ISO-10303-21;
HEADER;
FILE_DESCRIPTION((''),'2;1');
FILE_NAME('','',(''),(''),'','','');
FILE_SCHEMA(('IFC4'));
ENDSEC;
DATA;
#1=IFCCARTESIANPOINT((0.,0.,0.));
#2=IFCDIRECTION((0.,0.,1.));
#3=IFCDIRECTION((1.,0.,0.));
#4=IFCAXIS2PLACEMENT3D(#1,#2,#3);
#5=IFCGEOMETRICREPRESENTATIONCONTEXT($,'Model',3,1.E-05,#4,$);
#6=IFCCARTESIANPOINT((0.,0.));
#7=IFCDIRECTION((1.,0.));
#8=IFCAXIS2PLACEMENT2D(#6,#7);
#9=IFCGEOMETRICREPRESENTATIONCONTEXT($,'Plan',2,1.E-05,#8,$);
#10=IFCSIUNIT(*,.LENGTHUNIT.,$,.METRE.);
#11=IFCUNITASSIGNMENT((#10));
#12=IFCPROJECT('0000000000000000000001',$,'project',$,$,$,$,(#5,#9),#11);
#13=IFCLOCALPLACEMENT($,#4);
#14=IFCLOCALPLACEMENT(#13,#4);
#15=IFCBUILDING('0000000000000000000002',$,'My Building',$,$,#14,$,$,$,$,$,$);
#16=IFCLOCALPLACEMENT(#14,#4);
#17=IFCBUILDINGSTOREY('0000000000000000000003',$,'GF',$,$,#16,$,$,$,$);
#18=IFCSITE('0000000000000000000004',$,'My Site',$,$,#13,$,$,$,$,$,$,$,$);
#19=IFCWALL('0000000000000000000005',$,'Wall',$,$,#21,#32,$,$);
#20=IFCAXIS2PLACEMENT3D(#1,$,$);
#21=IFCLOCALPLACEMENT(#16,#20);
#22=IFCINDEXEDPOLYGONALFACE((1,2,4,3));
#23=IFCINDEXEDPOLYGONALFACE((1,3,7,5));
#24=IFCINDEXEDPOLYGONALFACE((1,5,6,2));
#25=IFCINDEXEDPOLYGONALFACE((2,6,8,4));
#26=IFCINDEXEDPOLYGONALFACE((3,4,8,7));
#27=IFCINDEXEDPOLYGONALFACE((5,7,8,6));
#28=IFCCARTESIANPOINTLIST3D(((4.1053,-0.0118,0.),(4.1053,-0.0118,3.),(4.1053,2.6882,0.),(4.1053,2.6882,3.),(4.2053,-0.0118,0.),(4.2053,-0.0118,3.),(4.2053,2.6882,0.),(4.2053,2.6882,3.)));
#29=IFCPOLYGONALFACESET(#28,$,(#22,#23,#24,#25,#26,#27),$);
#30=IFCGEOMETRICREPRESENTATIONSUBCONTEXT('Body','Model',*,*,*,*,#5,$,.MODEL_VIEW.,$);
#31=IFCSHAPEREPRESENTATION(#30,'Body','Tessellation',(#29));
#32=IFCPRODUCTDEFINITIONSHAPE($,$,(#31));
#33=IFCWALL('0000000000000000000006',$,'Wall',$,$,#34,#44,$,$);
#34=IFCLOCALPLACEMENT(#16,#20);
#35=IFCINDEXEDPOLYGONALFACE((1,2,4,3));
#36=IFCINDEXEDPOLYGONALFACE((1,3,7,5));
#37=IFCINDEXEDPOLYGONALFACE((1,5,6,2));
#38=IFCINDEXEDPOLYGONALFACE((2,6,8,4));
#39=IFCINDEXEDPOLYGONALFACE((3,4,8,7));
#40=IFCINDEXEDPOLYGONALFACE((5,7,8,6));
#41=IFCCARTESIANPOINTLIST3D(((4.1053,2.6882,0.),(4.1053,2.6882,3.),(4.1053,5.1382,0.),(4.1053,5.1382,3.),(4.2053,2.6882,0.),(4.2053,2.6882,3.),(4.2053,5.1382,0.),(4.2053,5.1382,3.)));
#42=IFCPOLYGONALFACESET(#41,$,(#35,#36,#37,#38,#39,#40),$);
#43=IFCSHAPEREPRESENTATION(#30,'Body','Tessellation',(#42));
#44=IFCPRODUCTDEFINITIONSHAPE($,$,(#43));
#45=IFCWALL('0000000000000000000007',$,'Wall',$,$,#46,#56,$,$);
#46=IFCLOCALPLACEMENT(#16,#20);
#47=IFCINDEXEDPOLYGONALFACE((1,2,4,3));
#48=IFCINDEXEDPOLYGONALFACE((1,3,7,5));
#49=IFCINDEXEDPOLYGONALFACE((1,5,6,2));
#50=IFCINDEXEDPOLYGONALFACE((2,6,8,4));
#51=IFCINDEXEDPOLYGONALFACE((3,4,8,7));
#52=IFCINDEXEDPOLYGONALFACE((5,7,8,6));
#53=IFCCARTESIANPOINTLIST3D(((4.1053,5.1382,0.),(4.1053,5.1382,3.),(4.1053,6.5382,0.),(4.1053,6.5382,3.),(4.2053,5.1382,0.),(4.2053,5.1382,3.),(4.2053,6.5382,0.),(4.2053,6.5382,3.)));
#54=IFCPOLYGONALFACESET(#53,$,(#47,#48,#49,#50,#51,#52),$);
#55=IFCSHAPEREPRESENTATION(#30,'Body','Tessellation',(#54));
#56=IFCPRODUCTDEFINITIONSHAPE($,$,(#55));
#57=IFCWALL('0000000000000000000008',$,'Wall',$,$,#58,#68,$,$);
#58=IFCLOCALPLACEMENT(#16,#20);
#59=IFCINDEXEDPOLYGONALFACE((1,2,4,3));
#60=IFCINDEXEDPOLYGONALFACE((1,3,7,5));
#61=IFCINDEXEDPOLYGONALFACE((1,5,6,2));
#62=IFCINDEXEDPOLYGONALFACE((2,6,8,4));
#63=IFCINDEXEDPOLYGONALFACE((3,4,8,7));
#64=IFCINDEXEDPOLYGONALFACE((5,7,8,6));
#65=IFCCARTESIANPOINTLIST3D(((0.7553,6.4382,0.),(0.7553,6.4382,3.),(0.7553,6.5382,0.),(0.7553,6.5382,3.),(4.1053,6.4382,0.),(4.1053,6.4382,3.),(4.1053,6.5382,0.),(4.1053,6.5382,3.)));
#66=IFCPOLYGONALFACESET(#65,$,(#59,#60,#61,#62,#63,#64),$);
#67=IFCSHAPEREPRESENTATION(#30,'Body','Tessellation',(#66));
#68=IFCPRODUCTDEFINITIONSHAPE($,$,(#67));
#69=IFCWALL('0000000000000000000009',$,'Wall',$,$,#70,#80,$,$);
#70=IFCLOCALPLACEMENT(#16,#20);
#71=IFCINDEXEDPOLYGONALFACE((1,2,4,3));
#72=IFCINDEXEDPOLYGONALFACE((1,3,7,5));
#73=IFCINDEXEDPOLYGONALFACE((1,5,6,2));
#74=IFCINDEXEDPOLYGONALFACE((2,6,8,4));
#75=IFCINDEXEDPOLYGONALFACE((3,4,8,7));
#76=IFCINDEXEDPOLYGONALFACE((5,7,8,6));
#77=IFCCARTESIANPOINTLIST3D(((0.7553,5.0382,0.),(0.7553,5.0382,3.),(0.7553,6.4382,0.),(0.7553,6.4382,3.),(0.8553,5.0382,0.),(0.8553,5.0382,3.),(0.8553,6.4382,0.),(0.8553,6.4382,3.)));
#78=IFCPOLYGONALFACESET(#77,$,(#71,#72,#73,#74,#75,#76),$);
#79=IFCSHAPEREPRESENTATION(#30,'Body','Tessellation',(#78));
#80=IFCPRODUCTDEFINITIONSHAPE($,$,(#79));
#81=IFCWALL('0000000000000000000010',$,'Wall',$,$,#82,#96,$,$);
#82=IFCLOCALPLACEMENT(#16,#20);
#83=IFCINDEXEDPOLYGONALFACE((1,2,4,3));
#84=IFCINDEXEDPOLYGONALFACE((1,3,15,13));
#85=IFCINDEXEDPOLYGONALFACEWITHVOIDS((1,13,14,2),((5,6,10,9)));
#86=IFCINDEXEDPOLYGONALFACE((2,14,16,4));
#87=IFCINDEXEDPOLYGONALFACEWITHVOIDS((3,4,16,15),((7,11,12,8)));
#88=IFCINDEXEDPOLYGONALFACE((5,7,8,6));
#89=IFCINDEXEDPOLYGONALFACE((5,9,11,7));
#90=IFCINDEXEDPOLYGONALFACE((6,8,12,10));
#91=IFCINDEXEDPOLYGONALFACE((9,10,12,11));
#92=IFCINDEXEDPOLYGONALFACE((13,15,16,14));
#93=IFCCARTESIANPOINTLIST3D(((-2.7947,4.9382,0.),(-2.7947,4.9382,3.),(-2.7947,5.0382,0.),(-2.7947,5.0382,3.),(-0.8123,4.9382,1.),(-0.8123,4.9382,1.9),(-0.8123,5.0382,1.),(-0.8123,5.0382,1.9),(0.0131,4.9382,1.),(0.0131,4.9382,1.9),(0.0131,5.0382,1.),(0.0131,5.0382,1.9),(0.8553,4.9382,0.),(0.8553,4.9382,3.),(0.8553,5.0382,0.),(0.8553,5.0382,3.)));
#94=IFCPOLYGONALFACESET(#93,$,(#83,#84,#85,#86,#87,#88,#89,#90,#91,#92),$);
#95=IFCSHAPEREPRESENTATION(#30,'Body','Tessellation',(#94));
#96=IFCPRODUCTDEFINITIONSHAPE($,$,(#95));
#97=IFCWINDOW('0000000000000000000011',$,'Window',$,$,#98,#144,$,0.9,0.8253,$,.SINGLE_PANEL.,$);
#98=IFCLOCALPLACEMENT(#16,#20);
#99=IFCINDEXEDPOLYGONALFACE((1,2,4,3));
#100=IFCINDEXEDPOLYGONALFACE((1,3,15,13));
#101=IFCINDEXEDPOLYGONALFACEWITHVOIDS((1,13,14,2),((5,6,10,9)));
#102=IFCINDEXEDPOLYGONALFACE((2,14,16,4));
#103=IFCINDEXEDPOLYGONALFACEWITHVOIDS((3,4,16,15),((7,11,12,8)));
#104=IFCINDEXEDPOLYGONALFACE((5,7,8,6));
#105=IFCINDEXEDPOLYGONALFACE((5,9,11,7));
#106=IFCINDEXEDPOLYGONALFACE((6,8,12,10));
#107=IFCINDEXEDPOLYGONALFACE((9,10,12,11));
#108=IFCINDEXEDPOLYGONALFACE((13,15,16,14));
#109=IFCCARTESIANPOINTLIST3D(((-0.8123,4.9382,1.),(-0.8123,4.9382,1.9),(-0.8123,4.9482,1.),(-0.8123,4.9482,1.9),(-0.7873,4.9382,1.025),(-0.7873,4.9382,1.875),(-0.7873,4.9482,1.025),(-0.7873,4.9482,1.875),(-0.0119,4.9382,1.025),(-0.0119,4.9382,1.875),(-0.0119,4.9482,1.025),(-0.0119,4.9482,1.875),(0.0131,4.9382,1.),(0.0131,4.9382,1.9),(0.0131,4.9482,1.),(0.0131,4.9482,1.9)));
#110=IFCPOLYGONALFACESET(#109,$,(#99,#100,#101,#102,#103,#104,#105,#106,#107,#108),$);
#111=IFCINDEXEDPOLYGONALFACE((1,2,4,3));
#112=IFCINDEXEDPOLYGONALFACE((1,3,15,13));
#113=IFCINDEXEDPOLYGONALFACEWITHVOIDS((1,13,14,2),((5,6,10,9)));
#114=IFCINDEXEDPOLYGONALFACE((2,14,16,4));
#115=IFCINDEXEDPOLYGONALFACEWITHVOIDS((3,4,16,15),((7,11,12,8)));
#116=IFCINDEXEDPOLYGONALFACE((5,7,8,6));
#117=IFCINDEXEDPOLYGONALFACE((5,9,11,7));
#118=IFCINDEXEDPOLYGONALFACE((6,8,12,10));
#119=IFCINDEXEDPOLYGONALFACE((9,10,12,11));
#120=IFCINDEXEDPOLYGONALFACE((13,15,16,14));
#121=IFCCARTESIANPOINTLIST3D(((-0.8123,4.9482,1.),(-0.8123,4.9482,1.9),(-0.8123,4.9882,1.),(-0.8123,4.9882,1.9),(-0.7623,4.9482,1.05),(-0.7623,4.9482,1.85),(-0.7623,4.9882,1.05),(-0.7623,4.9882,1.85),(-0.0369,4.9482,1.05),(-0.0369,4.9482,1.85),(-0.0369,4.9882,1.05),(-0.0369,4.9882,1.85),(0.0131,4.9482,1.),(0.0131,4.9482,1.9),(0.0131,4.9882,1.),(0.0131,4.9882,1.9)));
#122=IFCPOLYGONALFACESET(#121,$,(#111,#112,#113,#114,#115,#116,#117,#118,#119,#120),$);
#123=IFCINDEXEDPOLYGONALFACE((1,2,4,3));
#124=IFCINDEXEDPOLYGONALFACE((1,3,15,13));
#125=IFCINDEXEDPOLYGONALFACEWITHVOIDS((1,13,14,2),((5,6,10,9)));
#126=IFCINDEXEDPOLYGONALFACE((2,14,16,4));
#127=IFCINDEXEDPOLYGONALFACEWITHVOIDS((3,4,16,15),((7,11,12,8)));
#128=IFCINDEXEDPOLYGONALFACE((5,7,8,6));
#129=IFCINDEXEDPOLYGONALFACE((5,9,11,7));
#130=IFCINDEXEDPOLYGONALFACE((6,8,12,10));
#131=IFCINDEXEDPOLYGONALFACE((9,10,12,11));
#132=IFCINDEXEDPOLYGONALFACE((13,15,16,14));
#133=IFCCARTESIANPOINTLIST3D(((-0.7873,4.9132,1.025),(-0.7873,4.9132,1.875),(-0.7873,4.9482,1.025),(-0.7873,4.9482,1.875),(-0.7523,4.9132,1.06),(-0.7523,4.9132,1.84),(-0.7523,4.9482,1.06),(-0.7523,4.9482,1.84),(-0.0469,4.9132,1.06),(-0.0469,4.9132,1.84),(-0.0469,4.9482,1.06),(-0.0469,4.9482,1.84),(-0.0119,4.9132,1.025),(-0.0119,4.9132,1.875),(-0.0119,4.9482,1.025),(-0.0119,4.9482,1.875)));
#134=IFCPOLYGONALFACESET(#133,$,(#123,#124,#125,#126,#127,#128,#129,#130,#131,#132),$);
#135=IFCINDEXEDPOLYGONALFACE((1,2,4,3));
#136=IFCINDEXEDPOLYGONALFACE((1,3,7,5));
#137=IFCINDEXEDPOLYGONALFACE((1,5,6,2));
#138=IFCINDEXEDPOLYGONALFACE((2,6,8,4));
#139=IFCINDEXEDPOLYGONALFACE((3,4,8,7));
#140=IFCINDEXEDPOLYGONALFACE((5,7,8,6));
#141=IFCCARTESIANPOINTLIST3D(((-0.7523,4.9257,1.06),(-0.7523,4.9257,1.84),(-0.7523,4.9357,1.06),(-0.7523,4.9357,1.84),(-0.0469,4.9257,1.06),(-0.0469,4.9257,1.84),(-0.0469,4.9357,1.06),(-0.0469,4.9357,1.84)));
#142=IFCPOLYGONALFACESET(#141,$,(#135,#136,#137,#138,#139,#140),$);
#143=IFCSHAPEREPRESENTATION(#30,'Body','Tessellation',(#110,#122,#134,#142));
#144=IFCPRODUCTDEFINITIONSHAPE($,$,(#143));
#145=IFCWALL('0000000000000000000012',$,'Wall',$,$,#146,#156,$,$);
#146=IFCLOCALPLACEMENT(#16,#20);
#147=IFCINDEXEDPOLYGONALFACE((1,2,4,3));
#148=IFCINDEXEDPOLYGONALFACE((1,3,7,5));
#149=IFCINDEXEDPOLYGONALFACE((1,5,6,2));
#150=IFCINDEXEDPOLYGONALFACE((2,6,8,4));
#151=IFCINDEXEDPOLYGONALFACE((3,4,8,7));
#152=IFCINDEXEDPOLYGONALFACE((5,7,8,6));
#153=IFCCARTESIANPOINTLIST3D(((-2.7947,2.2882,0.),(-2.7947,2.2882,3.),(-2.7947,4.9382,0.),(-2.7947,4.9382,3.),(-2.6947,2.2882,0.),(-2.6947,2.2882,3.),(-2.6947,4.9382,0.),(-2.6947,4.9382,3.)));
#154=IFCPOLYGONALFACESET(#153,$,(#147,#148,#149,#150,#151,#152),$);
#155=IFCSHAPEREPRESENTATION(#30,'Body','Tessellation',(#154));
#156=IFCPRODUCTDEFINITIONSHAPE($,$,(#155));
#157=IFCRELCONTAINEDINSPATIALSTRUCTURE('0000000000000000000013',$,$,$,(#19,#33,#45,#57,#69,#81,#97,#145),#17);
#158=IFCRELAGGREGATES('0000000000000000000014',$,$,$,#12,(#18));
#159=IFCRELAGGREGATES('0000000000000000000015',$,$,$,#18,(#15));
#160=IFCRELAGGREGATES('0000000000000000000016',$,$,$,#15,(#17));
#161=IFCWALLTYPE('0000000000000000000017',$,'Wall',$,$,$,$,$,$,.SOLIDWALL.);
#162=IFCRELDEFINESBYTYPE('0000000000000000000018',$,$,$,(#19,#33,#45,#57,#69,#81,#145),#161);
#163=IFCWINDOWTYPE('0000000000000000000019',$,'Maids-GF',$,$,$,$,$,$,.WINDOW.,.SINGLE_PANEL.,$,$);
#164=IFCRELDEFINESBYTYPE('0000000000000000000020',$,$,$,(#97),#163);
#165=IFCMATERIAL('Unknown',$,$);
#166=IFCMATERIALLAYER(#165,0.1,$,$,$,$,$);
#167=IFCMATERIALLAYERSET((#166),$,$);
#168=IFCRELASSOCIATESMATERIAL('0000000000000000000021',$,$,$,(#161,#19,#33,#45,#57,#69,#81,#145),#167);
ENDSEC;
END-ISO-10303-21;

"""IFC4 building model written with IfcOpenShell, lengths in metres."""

from ifc_helpers import new_model, entity, si_unit, frame, origin_with_axes, origin_2d_with_axis, place, context, subcontext, project, spatial, line, indexed_curve, outline, extrude, shape, source, transform, mapped, material, layer, layer_set, layer_usage, type_object, type_shapes, element, fill, save


model = new_model("IFC4")

# Units and contexts
model_context = context("Model", 3, precision=1e-05, world=origin_with_axes())
plan_context = context("Plan", 2, precision=1e-05, world=origin_2d_with_axis())
body_context_1 = subcontext(model_context, "Body", "Model", "MODEL_VIEW")
body_context_2 = subcontext(plan_context, "Body", "Plan", "PLAN_VIEW")
ifc_project = project(units=[si_unit("LENGTHUNIT", "METRE")], contexts=[model_context, plan_context])

# Site, building, storey
site_placement = place(None, origin_with_axes())
site = spatial("IfcSite", under=ifc_project, at=site_placement, Name="My Site")
building_placement = place(site_placement, origin_with_axes())
building = spatial("IfcBuilding", under=site, at=building_placement, Name="My Building")
storey_placement = place(building_placement, origin_with_axes())
storey = spatial("IfcBuildingStorey", under=building, at=storey_placement, Name="GF")

# Shared definitions
ifc_material_1 = material(Name="Unknown")

# Shared definitions
ifc_layer_1 = layer(ifc_material_1, 0.1)
ifc_layer_set_1 = layer_set([ifc_layer_1])
wall_type = type_object("IfcWallType", Name="Wall", PredefinedType="SOLIDWALL", material=ifc_layer_set_1)

# Walls
ifc_layer_usage_1 = layer_usage(ifc_layer_set_1, "AXIS2", "POSITIVE", 0.0)
wall_1_placement = place(storey_placement, frame((4.2053, -0.0118, 0.0), z_axis=(0.0, 0.0, 1.0), x_axis=(0.0, 1.0, 0.0)))
element("IfcWall", 1, at=wall_1_placement, inside=storey, type_object=wall_type, material=ifc_layer_usage_1, Name="Wall", context=body_context_1, shape_type="SweptSolid", body=[
    extrude(outline(indexed_curve([(0.0, 0.0), (0.0, 0.1), (2.7, 0.1), (2.7, 0.0)], segments=[line(1, 2, 3, 4, 1)])), origin_with_axes(), (0.0, 0.0, 1.0), 3.0),
])
ifc_layer_usage_2 = layer_usage(ifc_layer_set_1, "AXIS2", "POSITIVE", 0.0)
wall_2_placement = place(storey_placement, frame((4.2053, 2.6882, 0.0), z_axis=(0.0, 0.0, 1.0), x_axis=(0.0, 1.0, 0.0)))
element("IfcWall", 2, at=wall_2_placement, inside=storey, type_object=wall_type, material=ifc_layer_usage_2, Name="Wall", context=body_context_1, shape_type="SweptSolid", body=[
    extrude(outline(indexed_curve([(0.0, 0.0), (0.0, 0.1), (2.45, 0.1), (2.45, 0.0)], segments=[line(1, 2, 3, 4, 1)])), origin_with_axes(), (0.0, 0.0, 1.0), 3.0),
])
ifc_layer_usage_3 = layer_usage(ifc_layer_set_1, "AXIS2", "POSITIVE", 0.0)
wall_3_placement = place(storey_placement, frame((4.2053, 5.1382, 0.0), z_axis=(0.0, 0.0, 1.0), x_axis=(0.0, 1.0, 0.0)))
element("IfcWall", 3, at=wall_3_placement, inside=storey, type_object=wall_type, material=ifc_layer_usage_3, Name="Wall", context=body_context_1, shape_type="SweptSolid", body=[
    extrude(outline(indexed_curve([(0.0, 0.0), (0.0, 0.1), (1.4, 0.1), (1.4, 0.0)], segments=[line(1, 2, 3, 4, 1)])), origin_with_axes(), (0.0, 0.0, 1.0), 3.0),
])
ifc_layer_usage_4 = layer_usage(ifc_layer_set_1, "AXIS2", "POSITIVE", 0.0)
wall_4_placement = place(storey_placement, frame((4.1053, 6.5382, 0.0), z_axis=(0.0, 0.0, 1.0), x_axis=(-1.0, 0.0, 0.0)))
element("IfcWall", 4, at=wall_4_placement, inside=storey, type_object=wall_type, material=ifc_layer_usage_4, Name="Wall", context=body_context_1, shape_type="SweptSolid", body=[
    extrude(outline(indexed_curve([(0.0, 0.0), (0.0, 0.1), (3.35, 0.1), (3.35, 0.0)], segments=[line(1, 2, 3, 4, 1)])), origin_with_axes(), (0.0, 0.0, 1.0), 3.0),
])
ifc_layer_usage_5 = layer_usage(ifc_layer_set_1, "AXIS2", "POSITIVE", 0.0)
wall_5_placement = place(storey_placement, frame((0.7553, 6.4382, 0.0), z_axis=(0.0, 0.0, 1.0), x_axis=(0.0, -1.0, 0.0)))
element("IfcWall", 5, at=wall_5_placement, inside=storey, type_object=wall_type, material=ifc_layer_usage_5, Name="Wall", context=body_context_1, shape_type="SweptSolid", body=[
    extrude(outline(indexed_curve([(0.0, 0.0), (0.0, 0.1), (1.4, 0.1), (1.4, 0.0)], segments=[line(1, 2, 3, 4, 1)])), origin_with_axes(), (0.0, 0.0, 1.0), 3.0),
])

# Wall, opening, window
ifc_layer_usage_6 = layer_usage(ifc_layer_set_1, "AXIS2", "POSITIVE", 0.0)
wall_6_placement = place(storey_placement, frame((0.8553, 5.0382, 0.0), z_axis=(0.0, 0.0, 1.0), x_axis=(-1.0, 0.0, 0.0)))
wall_6 = element("IfcWall", 6, at=wall_6_placement, inside=storey, type_object=wall_type, material=ifc_layer_usage_6, Name="Wall", context=body_context_1, shape_type="SweptSolid", body=[
    extrude(outline(indexed_curve([(0.0, 0.0), (0.0, 0.1), (3.65, 0.1), (3.65, 0.0)], segments=[line(1, 2, 3, 4, 1)])), origin_with_axes(), (0.0, 0.0, 1.0), 3.0),
])
shared_shape_1 = source(origin_with_axes(), body_context_1, "Body", "SweptSolid", [
    extrude(outline(indexed_curve([(0.0, 0.0), (0.8253, 0.0), (0.8253, 0.9), (0.0, 0.9)], segments=[line(1, 2, 3, 4, 1)])), frame((0.0, -0.6, 0.0), z_axis=(0.0, -1.0, 0.0), x_axis=(1.0, 0.0, 0.0)), (0.0, 0.0, -1.0), 1.2),
])
opening_1_placement = place(wall_6_placement, frame((0.8422, 0.0, 1.0), z_axis=(0.0, 0.0, 1.0), x_axis=(1.0, -0.000001, 0.0)))
opening_1 = element("IfcOpeningElement", 7, at=opening_1_placement, cuts=wall_6, PredefinedType="OPENING", context=body_context_1, shape_type="MappedRepresentation", body=[
    mapped(shared_shape_1, transform((0.0, 0.0, 0.0), x_axis=(1.0, 0.0, 0.0), y_axis=(0.0, 1.0, 0.0), z_axis=(0.0, 0.0, 1.0), scale=1.0)),
])
window_type_1 = type_object("IfcWindowType", Name="Maids-GF", PartitioningType="SINGLE_PANEL", PredefinedType="WINDOW")
shared_shape_2 = source(origin_with_axes(), body_context_1, "Body", "SweptSolid", [
    extrude(outline(indexed_curve([(0.0, 0.0), (0.8253, 0.0), (0.8253, 0.9), (0.0, 0.9)], segments=[line(1, 2, 3, 4, 1)]), holes=[indexed_curve([(0.025, 0.025), (0.8003, 0.025), (0.8003, 0.875), (0.025, 0.875)], segments=[line(1, 2, 3, 4, 1)])]), frame((0.0, 0.09, 0.0), z_axis=(0.0, -1.0, 0.0), x_axis=(1.0, 0.0, 0.0)), (0.0, 0.0, -1.0), 0.01),
    extrude(outline(indexed_curve([(0.0, 0.0), (0.8253, 0.0), (0.8253, 0.9), (0.0, 0.9)], segments=[line(1, 2, 3, 4, 1)]), holes=[indexed_curve([(0.05, 0.05), (0.7753, 0.05), (0.7753, 0.85), (0.05, 0.85)], segments=[line(1, 2, 3, 4, 1)])]), frame((0.0, 0.05, 0.0), z_axis=(0.0, -1.0, 0.0), x_axis=(1.0, 0.0, 0.0)), (0.0, 0.0, -1.0), 0.04),
    extrude(outline(indexed_curve([(0.0, 0.0), (0.7753, 0.0), (0.7753, 0.85), (0.0, 0.85)], segments=[line(1, 2, 3, 4, 1)]), holes=[indexed_curve([(0.035, 0.035), (0.7403, 0.035), (0.7403, 0.815), (0.035, 0.815)], segments=[line(1, 2, 3, 4, 1)])]), frame((0.025, 0.09, 0.025), z_axis=(0.0, -1.0, 0.0), x_axis=(1.0, 0.0, 0.0)), (0.0, 0.0, -1.0), 0.035),
    extrude(outline(indexed_curve([(0.035, 0.035), (0.7403, 0.035), (0.7403, 0.815), (0.035, 0.815)], segments=[line(1, 2, 3, 4, 1)])), frame((0.025, 0.1025, 0.025), z_axis=(0.0, -1.0, 0.0), x_axis=(1.0, 0.0, 0.0)), (0.0, 0.0, -1.0), 0.01),
])
shared_shape_3 = source(origin_with_axes(), body_context_2, "Body", "Curve2D", [
    entity("IfcIndexedPolyCurve", entity("IfcCartesianPointList2D", [[0.05, 0.05], [0.7753, 0.05]])),
    entity("IfcIndexedPolyCurve", entity("IfcCartesianPointList2D", [[0.0, 0.1], [0.025, 0.1], [0.025, 0.09], [0.05, 0.09], [0.05, 0.05], [0.0, 0.05]]), [entity("IfcLineIndex", [1, 2, 3, 4, 5, 6, 1])]),
    entity("IfcIndexedPolyCurve", entity("IfcCartesianPointList2D", [[0.8253, 0.1], [0.8003, 0.1], [0.8003, 0.09], [0.7753, 0.09], [0.7753, 0.05], [0.8253, 0.05]]), [entity("IfcLineIndex", [1, 2, 3, 4, 5, 6, 1])]),
    entity("IfcIndexedPolyCurve", entity("IfcCartesianPointList2D", [[0.025, 0.09], [0.06, 0.09], [0.06, 0.125], [0.025, 0.125]]), [entity("IfcLineIndex", [1, 2, 3, 4, 1])]),
    entity("IfcIndexedPolyCurve", entity("IfcCartesianPointList2D", [[0.8003, 0.09], [0.7653, 0.09], [0.7653, 0.125], [0.8003, 0.125]]), [entity("IfcLineIndex", [1, 2, 3, 4, 1])]),
    entity("IfcIndexedPolyCurve", entity("IfcCartesianPointList2D", [[0.06, 0.09], [0.7653, 0.09]])),
    entity("IfcIndexedPolyCurve", entity("IfcCartesianPointList2D", [[0.06, 0.125], [0.7653, 0.125]])),
    entity("IfcIndexedPolyCurve", entity("IfcCartesianPointList2D", [[0.06, 0.1075], [0.7653, 0.1075]])),
])
type_shapes(window_type_1, [shared_shape_2, shared_shape_3])
window_1_placement = place(opening_1_placement, frame((0.0, 0.0, 0.0), z_axis=(0.0, 0.0, 1.0), x_axis=(1.0, 0.0, 0.0)))
window_1 = element("IfcWindow", 8, at=window_1_placement, inside=storey, type_object=window_type_1, Name="Window", OverallHeight=0.9, OverallWidth=0.8253, PartitioningType="SINGLE_PANEL", shapes=[
    shape(body_context_1, "Body", "MappedRepresentation", [mapped(shared_shape_2, transform((0.0, 0.0, 0.0), x_axis=(1.0, 0.0, 0.0), y_axis=(0.0, 1.0, 0.0), z_axis=(0.0, 0.0, 1.0), scale=1.0))]),
    shape(body_context_2, "Body", "MappedRepresentation", [mapped(shared_shape_3, transform((0.0, 0.0, 0.0), x_axis=(1.0, 0.0, 0.0), y_axis=(0.0, 1.0, 0.0), z_axis=(0.0, 0.0, 1.0), scale=1.0))]),
])
fill(opening_1, window_1)

# Wall
ifc_layer_usage_7 = layer_usage(ifc_layer_set_1, "AXIS2", "POSITIVE", 0.0)
wall_7_placement = place(storey_placement, frame((-2.7947, 4.9382, 0.0), z_axis=(0.0, 0.0, 1.0), x_axis=(0.0, -1.0, 0.0)))
element("IfcWall", 9, at=wall_7_placement, inside=storey, type_object=wall_type, material=ifc_layer_usage_7, Name="Wall", context=body_context_1, shape_type="SweptSolid", body=[
    extrude(outline(indexed_curve([(0.0, 0.0), (0.0, 0.1), (2.65, 0.1), (2.65, 0.0)], segments=[line(1, 2, 3, 4, 1)])), origin_with_axes(), (0.0, 0.0, 1.0), 3.0),
])

save(model, "model.ifc")
